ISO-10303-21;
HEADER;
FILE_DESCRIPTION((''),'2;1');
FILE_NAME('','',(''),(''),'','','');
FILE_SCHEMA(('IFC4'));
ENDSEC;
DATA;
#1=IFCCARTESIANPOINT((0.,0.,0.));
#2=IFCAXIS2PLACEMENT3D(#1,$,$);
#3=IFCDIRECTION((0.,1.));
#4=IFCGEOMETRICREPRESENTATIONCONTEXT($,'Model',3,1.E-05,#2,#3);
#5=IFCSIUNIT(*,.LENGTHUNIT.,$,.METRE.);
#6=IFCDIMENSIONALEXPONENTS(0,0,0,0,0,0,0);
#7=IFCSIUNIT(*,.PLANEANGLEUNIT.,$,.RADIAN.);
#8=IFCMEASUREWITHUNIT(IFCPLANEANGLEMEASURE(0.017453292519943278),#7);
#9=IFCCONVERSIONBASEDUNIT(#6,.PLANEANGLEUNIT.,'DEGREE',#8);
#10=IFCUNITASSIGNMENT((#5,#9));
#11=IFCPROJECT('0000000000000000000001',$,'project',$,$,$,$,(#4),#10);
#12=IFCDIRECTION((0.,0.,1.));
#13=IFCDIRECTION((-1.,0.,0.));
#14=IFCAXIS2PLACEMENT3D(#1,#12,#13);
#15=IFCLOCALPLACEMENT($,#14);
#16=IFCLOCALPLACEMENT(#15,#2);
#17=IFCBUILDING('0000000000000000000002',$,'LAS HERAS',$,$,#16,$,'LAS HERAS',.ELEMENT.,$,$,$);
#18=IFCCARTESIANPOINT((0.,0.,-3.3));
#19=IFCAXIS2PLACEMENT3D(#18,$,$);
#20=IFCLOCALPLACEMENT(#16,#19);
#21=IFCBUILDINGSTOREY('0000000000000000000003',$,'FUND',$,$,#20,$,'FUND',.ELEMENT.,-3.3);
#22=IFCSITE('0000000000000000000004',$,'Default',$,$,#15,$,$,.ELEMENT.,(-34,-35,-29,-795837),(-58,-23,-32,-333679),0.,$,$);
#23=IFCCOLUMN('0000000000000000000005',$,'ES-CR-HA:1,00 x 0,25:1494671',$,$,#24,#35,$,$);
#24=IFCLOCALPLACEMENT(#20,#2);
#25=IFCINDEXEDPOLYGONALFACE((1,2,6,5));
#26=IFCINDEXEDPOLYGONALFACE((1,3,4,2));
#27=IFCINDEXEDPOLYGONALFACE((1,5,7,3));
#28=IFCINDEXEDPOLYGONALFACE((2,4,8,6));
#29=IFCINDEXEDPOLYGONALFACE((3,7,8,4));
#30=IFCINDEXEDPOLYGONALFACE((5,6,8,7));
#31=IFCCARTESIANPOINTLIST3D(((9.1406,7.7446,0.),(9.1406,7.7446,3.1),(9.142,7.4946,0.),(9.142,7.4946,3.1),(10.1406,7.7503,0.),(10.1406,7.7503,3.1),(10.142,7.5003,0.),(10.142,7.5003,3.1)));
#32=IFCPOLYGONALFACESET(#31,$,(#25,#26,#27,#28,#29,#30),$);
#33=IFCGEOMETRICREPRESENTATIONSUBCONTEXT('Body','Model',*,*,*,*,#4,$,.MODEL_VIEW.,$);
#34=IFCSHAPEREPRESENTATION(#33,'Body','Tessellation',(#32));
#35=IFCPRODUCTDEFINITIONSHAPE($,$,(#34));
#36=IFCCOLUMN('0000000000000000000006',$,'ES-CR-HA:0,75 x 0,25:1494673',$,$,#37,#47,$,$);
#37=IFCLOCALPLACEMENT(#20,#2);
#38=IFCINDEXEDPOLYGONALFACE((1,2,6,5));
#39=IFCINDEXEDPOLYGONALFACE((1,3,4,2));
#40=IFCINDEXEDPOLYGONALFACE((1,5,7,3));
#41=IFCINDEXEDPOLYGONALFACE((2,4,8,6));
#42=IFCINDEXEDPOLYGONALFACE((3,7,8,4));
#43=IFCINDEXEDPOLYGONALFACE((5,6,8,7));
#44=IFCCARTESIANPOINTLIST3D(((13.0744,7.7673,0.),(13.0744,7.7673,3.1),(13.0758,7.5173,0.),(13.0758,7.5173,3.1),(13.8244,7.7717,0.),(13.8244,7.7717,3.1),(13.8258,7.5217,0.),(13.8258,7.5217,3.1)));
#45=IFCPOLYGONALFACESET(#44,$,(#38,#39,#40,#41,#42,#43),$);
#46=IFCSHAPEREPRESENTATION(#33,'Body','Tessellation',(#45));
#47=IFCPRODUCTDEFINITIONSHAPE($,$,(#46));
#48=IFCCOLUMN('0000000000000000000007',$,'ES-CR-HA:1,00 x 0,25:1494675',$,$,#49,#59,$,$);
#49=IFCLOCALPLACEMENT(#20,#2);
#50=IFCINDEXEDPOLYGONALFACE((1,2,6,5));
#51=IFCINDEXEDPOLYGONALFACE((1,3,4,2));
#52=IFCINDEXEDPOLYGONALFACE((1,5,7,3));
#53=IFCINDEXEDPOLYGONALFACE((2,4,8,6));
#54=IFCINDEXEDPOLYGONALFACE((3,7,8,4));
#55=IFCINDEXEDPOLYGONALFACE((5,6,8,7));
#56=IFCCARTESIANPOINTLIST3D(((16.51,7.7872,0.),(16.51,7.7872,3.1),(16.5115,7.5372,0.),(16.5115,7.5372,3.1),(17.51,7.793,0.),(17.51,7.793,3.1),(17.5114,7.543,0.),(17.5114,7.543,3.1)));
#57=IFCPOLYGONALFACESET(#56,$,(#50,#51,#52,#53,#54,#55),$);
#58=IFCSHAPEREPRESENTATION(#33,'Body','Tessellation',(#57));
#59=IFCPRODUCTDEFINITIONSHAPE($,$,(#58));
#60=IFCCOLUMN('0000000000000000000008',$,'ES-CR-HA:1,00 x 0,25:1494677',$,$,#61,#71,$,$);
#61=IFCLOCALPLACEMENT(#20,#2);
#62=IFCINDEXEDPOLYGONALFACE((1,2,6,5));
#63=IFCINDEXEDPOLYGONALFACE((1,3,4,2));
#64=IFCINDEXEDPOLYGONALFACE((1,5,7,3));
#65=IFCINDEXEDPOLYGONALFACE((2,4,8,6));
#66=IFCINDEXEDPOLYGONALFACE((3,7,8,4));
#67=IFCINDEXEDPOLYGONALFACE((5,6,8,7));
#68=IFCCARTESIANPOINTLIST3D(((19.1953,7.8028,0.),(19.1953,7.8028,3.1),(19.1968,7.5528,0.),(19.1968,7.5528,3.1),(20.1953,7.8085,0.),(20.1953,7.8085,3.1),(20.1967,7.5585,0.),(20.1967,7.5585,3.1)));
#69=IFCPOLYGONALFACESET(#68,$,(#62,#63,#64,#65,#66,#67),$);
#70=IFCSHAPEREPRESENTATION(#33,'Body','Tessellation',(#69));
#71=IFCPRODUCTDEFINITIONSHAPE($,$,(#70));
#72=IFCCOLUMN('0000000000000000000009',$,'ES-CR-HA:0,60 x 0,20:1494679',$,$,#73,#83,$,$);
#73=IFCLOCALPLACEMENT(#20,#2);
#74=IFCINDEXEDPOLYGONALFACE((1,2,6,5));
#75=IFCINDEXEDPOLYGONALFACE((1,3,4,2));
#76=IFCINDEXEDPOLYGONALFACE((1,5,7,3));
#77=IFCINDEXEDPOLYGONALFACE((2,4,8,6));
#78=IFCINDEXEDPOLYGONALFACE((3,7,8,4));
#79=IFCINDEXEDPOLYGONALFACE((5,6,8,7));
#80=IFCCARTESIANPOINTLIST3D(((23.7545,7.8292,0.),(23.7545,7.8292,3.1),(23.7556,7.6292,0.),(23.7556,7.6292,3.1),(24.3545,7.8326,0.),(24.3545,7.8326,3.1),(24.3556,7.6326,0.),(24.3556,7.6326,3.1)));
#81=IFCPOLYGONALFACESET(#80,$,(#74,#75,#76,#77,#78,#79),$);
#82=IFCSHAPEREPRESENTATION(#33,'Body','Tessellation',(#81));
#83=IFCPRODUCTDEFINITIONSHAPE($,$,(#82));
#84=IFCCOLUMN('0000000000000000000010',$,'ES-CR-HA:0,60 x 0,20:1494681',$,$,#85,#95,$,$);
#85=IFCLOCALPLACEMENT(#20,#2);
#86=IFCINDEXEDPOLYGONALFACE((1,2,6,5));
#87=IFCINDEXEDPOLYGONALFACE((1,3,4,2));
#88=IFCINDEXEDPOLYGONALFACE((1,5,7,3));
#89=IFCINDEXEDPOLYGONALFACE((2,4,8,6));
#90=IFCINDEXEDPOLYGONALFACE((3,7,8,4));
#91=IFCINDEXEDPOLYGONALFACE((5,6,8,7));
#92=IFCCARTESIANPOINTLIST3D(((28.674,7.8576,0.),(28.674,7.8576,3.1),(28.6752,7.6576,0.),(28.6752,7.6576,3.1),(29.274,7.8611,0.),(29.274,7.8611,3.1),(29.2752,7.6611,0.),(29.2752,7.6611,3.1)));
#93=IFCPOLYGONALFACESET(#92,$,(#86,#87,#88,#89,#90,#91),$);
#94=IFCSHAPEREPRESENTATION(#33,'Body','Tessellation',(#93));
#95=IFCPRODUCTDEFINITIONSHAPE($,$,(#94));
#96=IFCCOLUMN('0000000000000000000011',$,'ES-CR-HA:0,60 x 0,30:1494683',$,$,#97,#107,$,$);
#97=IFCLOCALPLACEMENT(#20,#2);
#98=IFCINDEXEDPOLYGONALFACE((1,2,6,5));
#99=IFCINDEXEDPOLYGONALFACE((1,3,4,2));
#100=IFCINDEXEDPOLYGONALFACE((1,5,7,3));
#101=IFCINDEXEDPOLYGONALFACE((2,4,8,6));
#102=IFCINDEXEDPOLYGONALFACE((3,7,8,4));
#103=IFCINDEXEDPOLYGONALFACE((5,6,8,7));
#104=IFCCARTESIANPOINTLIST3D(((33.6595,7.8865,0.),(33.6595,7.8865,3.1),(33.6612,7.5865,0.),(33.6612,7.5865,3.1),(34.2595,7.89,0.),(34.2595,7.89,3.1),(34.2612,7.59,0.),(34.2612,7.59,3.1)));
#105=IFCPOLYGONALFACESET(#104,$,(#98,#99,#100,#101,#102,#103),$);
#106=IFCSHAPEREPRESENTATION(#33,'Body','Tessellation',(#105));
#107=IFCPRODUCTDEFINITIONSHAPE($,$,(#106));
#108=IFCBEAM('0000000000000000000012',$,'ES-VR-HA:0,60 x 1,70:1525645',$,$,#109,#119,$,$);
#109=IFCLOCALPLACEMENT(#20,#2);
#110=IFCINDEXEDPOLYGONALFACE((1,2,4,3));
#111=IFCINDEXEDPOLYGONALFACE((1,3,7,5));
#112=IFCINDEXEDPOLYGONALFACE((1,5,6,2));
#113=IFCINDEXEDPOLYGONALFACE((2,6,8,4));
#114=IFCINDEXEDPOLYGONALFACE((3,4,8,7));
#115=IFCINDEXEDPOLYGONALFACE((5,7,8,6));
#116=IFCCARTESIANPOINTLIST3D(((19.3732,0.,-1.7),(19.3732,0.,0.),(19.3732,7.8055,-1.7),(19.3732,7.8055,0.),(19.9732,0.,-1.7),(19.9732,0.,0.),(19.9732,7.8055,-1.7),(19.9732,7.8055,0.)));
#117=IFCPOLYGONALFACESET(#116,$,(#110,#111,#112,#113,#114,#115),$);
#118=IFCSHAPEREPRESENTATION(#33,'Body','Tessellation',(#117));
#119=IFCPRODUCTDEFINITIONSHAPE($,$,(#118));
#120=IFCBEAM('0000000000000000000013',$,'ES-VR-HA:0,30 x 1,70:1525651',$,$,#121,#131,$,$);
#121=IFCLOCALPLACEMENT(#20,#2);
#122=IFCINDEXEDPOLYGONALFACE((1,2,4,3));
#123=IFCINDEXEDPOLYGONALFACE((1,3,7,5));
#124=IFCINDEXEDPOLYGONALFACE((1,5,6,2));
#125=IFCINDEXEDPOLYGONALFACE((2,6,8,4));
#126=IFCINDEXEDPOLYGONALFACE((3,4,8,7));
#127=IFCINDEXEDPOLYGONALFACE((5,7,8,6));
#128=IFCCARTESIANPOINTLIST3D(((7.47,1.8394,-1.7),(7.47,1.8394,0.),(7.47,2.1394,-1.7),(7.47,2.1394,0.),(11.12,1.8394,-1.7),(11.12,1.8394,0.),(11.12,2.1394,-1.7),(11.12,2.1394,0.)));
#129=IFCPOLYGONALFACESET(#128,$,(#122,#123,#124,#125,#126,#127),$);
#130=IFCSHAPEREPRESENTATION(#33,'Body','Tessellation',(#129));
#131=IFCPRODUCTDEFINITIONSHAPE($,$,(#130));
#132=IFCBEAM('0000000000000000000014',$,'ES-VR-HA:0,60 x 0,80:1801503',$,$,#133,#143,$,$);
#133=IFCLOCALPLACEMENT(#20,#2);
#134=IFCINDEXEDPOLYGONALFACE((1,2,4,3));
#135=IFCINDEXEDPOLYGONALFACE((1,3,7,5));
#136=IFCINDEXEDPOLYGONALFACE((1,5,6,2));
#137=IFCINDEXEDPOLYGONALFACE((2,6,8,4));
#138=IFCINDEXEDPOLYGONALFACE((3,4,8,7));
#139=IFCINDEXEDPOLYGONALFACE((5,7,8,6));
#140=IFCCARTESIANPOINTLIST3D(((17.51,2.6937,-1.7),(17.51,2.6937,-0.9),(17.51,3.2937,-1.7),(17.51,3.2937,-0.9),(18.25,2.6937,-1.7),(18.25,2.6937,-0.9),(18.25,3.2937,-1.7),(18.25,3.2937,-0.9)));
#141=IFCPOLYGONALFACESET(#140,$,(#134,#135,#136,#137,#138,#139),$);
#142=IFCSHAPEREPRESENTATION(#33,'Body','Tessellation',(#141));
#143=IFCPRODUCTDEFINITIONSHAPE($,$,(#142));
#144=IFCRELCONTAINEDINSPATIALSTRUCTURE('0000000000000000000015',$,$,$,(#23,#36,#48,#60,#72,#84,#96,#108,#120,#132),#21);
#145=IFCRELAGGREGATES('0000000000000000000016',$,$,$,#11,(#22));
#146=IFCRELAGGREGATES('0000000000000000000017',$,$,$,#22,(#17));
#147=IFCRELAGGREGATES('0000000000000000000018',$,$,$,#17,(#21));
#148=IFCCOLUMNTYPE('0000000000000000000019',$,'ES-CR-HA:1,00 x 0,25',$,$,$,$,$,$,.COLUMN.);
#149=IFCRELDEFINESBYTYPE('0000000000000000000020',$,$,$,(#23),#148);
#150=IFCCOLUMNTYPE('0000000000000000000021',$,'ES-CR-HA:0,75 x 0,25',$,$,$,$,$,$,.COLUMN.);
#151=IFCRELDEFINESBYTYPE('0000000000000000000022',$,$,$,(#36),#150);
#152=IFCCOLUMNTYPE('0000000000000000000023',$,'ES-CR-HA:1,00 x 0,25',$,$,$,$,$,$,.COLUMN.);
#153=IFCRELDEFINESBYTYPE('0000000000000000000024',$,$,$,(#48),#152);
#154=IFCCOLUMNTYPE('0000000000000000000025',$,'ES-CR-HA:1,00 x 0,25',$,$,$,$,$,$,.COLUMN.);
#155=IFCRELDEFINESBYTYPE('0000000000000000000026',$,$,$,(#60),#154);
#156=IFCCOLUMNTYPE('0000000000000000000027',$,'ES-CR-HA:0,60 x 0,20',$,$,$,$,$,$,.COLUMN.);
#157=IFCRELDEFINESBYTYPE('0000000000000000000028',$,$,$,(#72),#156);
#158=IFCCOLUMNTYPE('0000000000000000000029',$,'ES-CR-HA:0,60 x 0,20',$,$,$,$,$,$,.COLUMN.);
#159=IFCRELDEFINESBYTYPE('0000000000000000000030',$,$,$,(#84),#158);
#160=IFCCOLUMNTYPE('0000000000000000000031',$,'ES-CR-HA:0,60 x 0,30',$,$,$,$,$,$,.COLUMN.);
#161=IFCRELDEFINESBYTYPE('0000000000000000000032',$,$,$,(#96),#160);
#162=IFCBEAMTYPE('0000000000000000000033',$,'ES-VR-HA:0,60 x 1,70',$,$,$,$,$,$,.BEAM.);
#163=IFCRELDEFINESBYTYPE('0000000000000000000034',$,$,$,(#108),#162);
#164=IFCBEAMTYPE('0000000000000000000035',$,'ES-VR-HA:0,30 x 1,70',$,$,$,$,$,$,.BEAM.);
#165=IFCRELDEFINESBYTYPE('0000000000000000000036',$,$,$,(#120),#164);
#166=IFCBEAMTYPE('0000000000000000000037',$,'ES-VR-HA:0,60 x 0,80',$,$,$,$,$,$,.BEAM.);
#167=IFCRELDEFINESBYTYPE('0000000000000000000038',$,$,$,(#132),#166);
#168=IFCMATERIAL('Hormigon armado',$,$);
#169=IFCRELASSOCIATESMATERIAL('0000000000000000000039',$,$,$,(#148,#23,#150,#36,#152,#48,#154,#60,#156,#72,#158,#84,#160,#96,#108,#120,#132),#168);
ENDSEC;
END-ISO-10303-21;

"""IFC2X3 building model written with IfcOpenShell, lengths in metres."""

from ifc_helpers import new_model, entity, si_unit, converted_unit, direction, frame, frame_2d, origin, origin_2d_with_axis, place, context, subcontext, project, spatial, rectangle, extrude, source, transform, mapped, material, type_object, type_shapes, element, save


model = new_model("IFC2X3")

# Units and contexts
model_context = context("Model", 3, precision=1e-05, world=origin(), true_north=direction((0.0, 1.0)))
body_context = subcontext(model_context, "Body", "Model", "MODEL_VIEW")
ifc_project = project(units=[si_unit("LENGTHUNIT", "METRE"), converted_unit("PLANEANGLEUNIT", "DEGREE", entity("IfcPlaneAngleMeasure", 0.017453292519943278), si_unit("PLANEANGLEUNIT", "RADIAN"), dimensions=[0, 0, 0, 0, 0, 0, 0])], contexts=[model_context])

# Site, building, storey
site_placement = place(None, frame((0.0, 0.0, 0.0), z_axis=(0.0, 0.0, 1.0), x_axis=(-1.0, 0.0, 0.0)))
site = spatial("IfcSite", under=ifc_project, at=site_placement, Name="Default", CompositionType="ELEMENT", RefLatitude=(-34, -35, -29, -795837), RefLongitude=(-58, -23, -32, -333679), RefElevation=0.0)
building_placement = place(site_placement, origin())
building = spatial("IfcBuilding", under=site, at=building_placement, Name="LAS HERAS", LongName="LAS HERAS", CompositionType="ELEMENT")
storey_placement = place(building_placement, frame((0.0, 0.0, -3.3)))
storey = spatial("IfcBuildingStorey", under=building, at=storey_placement, Name="FUND", LongName="FUND", CompositionType="ELEMENT", Elevation=-3.3)

# Columns
ifc_material = material(Name="Hormigon armado")
column_type_1 = type_object("IfcColumnType", Name="ES-CR-HA:1,00 x 0,25", PredefinedType="COLUMN", material=ifc_material)
shared_shape_1 = source(origin(), body_context, "Body", "SweptSolid", [
    extrude(rectangle(XDim=1.0, YDim=0.25, at=frame_2d((0.0, 0.0), x_axis=(1.0, 0.0))), frame((9.6413, 7.6224, -3.3), z_axis=(0.0, 0.0, 1.0), x_axis=(-0.999983, -0.00576, 0.0)), (0.0, 0.0, 1.0), 3.1),
])
type_shapes(column_type_1, [shared_shape_1])
column_1_placement = place(storey_placement, frame((0.0, 0.0, 3.3)))
element("IfcColumn", 1, at=column_1_placement, inside=storey, type_object=column_type_1, material=ifc_material, Name="ES-CR-HA:1,00 x 0,25:1494671", context=body_context, shape_type="MappedRepresentation", body=[
    mapped(shared_shape_1, transform((0.0, 0.0, 0.0), scale=1.0)),
])
column_type_2 = type_object("IfcColumnType", Name="ES-CR-HA:0,75 x 0,25", PredefinedType="COLUMN", material=ifc_material)
shared_shape_2 = source(origin(), body_context, "Body", "SweptSolid", [
    extrude(rectangle(XDim=0.75, YDim=0.25, at=frame_2d((0.0, 0.0), x_axis=(1.0, 0.0))), frame((13.4501, 7.6445, -3.3), z_axis=(0.0, 0.0, 1.0), x_axis=(-0.999983, -0.00576, 0.0)), (0.0, 0.0, 1.0), 3.1),
])
type_shapes(column_type_2, [shared_shape_2])
column_2_placement = place(storey_placement, frame((0.0, 0.0, 3.3)))
element("IfcColumn", 2, at=column_2_placement, inside=storey, type_object=column_type_2, material=ifc_material, Name="ES-CR-HA:0,75 x 0,25:1494673", context=body_context, shape_type="MappedRepresentation", body=[
    mapped(shared_shape_2, transform((0.0, 0.0, 0.0), scale=1.0)),
])
column_type_3 = type_object("IfcColumnType", Name="ES-CR-HA:1,00 x 0,25", PredefinedType="COLUMN", material=ifc_material)
shared_shape_3 = source(origin(), body_context, "Body", "SweptSolid", [
    extrude(rectangle(XDim=1.0, YDim=0.25, at=frame_2d((0.0, 0.0), x_axis=(1.0, 0.0))), frame((17.0107, 7.6651, -3.3), z_axis=(0.0, 0.0, 1.0), x_axis=(-0.999983, -0.00576, 0.0)), (0.0, 0.0, 1.0), 3.1),
])
type_shapes(column_type_3, [shared_shape_3])
column_3_placement = place(storey_placement, frame((0.0, 0.0, 3.3)))
element("IfcColumn", 3, at=column_3_placement, inside=storey, type_object=column_type_3, material=ifc_material, Name="ES-CR-HA:1,00 x 0,25:1494675", context=body_context, shape_type="MappedRepresentation", body=[
    mapped(shared_shape_3, transform((0.0, 0.0, 0.0), scale=1.0)),
])
column_type_4 = type_object("IfcColumnType", Name="ES-CR-HA:1,00 x 0,25", PredefinedType="COLUMN", material=ifc_material)
shared_shape_4 = source(origin(), body_context, "Body", "SweptSolid", [
    extrude(rectangle(XDim=1.0, YDim=0.25, at=frame_2d((0.0, 0.0), x_axis=(1.0, 0.0))), frame((19.696, 7.6806, -3.3), z_axis=(0.0, 0.0, 1.0), x_axis=(-0.999983, -0.00576, 0.0)), (0.0, 0.0, 1.0), 3.1),
])
type_shapes(column_type_4, [shared_shape_4])
column_4_placement = place(storey_placement, frame((0.0, 0.0, 3.3)))
element("IfcColumn", 4, at=column_4_placement, inside=storey, type_object=column_type_4, material=ifc_material, Name="ES-CR-HA:1,00 x 0,25:1494677", context=body_context, shape_type="MappedRepresentation", body=[
    mapped(shared_shape_4, transform((0.0, 0.0, 0.0), scale=1.0)),
])
column_type_5 = type_object("IfcColumnType", Name="ES-CR-HA:0,60 x 0,20", PredefinedType="COLUMN", material=ifc_material)
shared_shape_5 = source(origin(), body_context, "Body", "SweptSolid", [
    extrude(rectangle(XDim=0.6, YDim=0.2, at=frame_2d((0.0, 0.0), x_axis=(1.0, 0.0))), frame((24.0551, 7.7309, -3.3), z_axis=(0.0, 0.0, 1.0), x_axis=(-0.999983, -0.00576, 0.0)), (0.0, 0.0, 1.0), 3.1),
])
type_shapes(column_type_5, [shared_shape_5])
column_5_placement = place(storey_placement, frame((0.0, 0.0, 3.3)))
element("IfcColumn", 5, at=column_5_placement, inside=storey, type_object=column_type_5, material=ifc_material, Name="ES-CR-HA:0,60 x 0,20:1494679", context=body_context, shape_type="MappedRepresentation", body=[
    mapped(shared_shape_5, transform((0.0, 0.0, 0.0), scale=1.0)),
])
column_type_6 = type_object("IfcColumnType", Name="ES-CR-HA:0,60 x 0,20", PredefinedType="COLUMN", material=ifc_material)
shared_shape_6 = source(origin(), body_context, "Body", "SweptSolid", [
    extrude(rectangle(XDim=0.6, YDim=0.2, at=frame_2d((0.0, 0.0), x_axis=(1.0, 0.0))), frame((28.9746, 7.7594, -3.3), z_axis=(0.0, 0.0, 1.0), x_axis=(-0.999983, -0.00576, 0.0)), (0.0, 0.0, 1.0), 3.1),
])
type_shapes(column_type_6, [shared_shape_6])
column_6_placement = place(storey_placement, frame((0.0, 0.0, 3.3)))
element("IfcColumn", 6, at=column_6_placement, inside=storey, type_object=column_type_6, material=ifc_material, Name="ES-CR-HA:0,60 x 0,20:1494681", context=body_context, shape_type="MappedRepresentation", body=[
    mapped(shared_shape_6, transform((0.0, 0.0, 0.0), scale=1.0)),
])
column_type_7 = type_object("IfcColumnType", Name="ES-CR-HA:0,60 x 0,30", PredefinedType="COLUMN", material=ifc_material)
shared_shape_7 = source(origin(), body_context, "Body", "SweptSolid", [
    extrude(rectangle(XDim=0.6, YDim=0.3, at=frame_2d((0.0, 0.0), x_axis=(1.0, 0.0))), frame((33.9603, 7.7382, -3.3), z_axis=(0.0, 0.0, 1.0), x_axis=(-0.999983, -0.00576, 0.0)), (0.0, 0.0, 1.0), 3.1),
])
type_shapes(column_type_7, [shared_shape_7])
column_7_placement = place(storey_placement, frame((0.0, 0.0, 3.3)))
element("IfcColumn", 7, at=column_7_placement, inside=storey, type_object=column_type_7, material=ifc_material, Name="ES-CR-HA:0,60 x 0,30:1494683", context=body_context, shape_type="MappedRepresentation", body=[
    mapped(shared_shape_7, transform((0.0, 0.0, 0.0), scale=1.0)),
])

# Beams
beam_type_1 = type_object("IfcBeamType", Name="ES-VR-HA:0,60 x 1,70", PredefinedType="BEAM")
beam_1_placement = place(storey_placement, frame((19.6732, 7.8055, 0.0), z_axis=(0.0, 0.0, 1.0), x_axis=(0.0, -1.0, 0.0)))
element("IfcBeam", 8, at=beam_1_placement, inside=storey, type_object=beam_type_1, material=ifc_material, Name="ES-VR-HA:0,60 x 1,70:1525645", context=body_context, shape_type="SweptSolid", body=[
    extrude(rectangle(XDim=1.7, YDim=0.6, at=frame_2d((0.0, 0.0), x_axis=(1.0, 0.0))), frame((0.0, 0.0, -0.85), z_axis=(1.0, 0.0, 0.0), x_axis=(0.0, 0.0, -1.0)), (0.0, 0.0, 1.0), 7.8055),
])
beam_type_2 = type_object("IfcBeamType", Name="ES-VR-HA:0,30 x 1,70", PredefinedType="BEAM")
beam_2_placement = place(storey_placement, frame((7.17, 1.9894, 0.0)))
element("IfcBeam", 9, at=beam_2_placement, inside=storey, type_object=beam_type_2, material=ifc_material, Name="ES-VR-HA:0,30 x 1,70:1525651", context=body_context, shape_type="SweptSolid", body=[
    extrude(rectangle(XDim=1.7, YDim=0.3, at=origin_2d_with_axis()), frame((0.3, 0.0, -0.85), z_axis=(1.0, 0.0, 0.0), x_axis=(0.0, 0.0, -1.0)), (0.0, 0.0, 1.0), 3.65),
])
beam_type_3 = type_object("IfcBeamType", Name="ES-VR-HA:0,60 x 0,80", PredefinedType="BEAM")
beam_3_placement = place(storey_placement, frame((18.2506, 2.9937, -0.9), z_axis=(0.0, 0.0, 1.0), x_axis=(-1.0, 0.0, 0.0)))
element("IfcBeam", 10, at=beam_3_placement, inside=storey, type_object=beam_type_3, material=ifc_material, Name="ES-VR-HA:0,60 x 0,80:1801503", context=body_context, shape_type="SweptSolid", body=[
    extrude(rectangle(XDim=0.8, YDim=0.6, at=frame_2d((0.0, 0.0), x_axis=(1.0, 0.0))), frame((0.0006, 0.0, -0.4), z_axis=(1.0, 0.0, 0.0), x_axis=(0.0, 0.0, -1.0)), (0.0, 0.0, 1.0), 0.74),
])

save(model, "model.ifc")
